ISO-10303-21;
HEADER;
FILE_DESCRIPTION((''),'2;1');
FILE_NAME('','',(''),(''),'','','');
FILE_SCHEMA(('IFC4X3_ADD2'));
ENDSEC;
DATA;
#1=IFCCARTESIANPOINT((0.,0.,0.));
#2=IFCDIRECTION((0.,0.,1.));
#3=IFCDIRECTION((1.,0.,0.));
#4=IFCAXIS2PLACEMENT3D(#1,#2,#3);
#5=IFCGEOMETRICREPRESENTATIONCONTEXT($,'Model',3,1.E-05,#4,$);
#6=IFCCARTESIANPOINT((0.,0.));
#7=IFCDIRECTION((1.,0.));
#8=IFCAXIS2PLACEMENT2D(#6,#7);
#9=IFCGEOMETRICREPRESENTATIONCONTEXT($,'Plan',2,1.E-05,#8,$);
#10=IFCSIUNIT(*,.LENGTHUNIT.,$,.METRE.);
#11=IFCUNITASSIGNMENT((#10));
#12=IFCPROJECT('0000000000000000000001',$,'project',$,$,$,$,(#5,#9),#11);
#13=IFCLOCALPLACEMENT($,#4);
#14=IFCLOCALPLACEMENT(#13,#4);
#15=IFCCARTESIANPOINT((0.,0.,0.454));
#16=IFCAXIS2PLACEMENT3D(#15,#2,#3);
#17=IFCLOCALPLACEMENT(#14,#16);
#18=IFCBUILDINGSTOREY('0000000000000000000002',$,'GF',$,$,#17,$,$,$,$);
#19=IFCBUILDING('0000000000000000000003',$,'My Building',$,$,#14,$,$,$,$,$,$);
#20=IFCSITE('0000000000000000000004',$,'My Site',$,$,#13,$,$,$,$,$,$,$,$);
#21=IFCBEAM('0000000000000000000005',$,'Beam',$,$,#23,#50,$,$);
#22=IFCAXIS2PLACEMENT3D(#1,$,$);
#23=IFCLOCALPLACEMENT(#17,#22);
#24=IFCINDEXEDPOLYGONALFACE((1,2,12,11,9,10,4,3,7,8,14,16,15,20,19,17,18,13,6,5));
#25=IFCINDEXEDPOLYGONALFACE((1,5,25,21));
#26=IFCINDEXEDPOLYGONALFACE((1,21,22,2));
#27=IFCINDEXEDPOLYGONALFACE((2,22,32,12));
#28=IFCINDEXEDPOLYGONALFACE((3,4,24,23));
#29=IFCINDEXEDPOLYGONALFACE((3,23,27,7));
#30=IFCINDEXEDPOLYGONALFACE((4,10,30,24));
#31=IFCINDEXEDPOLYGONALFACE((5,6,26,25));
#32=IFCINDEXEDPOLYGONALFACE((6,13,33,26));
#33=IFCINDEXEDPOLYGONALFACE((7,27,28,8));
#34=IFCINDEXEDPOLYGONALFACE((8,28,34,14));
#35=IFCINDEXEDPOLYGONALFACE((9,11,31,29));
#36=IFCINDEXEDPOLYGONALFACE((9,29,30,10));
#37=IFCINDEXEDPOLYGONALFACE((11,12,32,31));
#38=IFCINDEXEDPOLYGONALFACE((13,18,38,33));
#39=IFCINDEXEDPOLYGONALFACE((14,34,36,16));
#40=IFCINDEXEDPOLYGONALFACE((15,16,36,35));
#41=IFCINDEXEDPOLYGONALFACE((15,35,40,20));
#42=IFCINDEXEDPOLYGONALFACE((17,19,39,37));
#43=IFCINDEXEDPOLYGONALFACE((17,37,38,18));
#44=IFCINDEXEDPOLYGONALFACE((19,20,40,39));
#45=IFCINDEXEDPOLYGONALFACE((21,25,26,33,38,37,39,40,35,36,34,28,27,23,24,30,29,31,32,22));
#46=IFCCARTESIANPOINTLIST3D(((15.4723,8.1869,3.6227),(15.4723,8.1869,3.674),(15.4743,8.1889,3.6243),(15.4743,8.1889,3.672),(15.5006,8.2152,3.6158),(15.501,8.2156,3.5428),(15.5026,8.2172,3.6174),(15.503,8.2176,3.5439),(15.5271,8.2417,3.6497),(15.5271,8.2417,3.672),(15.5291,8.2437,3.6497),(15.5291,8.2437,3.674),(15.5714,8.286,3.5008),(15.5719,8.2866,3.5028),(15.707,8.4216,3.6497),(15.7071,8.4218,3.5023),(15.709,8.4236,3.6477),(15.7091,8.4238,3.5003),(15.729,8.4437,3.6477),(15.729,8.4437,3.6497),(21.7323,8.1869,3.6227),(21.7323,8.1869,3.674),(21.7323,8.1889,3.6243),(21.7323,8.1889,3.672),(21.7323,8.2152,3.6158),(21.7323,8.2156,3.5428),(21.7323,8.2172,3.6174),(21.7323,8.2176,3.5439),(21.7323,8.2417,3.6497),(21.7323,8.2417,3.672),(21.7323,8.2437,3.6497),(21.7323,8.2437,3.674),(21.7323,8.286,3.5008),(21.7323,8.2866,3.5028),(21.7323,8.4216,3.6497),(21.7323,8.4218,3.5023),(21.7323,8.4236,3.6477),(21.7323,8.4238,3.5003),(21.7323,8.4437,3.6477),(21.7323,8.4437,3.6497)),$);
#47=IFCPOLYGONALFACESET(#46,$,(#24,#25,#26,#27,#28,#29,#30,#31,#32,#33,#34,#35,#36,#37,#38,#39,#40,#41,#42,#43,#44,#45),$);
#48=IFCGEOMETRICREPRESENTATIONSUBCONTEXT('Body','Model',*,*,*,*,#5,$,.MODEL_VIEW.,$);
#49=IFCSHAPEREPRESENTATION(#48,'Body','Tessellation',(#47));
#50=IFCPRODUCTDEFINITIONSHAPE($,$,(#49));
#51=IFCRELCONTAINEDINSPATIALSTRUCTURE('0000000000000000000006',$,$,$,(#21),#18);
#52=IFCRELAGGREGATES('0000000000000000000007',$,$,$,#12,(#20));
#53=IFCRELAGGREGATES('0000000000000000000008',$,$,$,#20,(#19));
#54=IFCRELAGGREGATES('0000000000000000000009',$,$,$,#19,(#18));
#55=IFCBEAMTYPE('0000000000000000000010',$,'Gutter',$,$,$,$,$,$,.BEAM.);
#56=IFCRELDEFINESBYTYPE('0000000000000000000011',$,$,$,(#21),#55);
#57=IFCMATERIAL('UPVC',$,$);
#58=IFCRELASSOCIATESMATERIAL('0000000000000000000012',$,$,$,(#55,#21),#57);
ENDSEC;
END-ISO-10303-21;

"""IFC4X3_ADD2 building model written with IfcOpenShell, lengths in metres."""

from ifc_helpers import new_model, si_unit, frame, origin_with_axes, origin_2d_with_axis, place, context, subcontext, project, spatial, indexed_curve, outline, extrude, clip, halfspace, material, material_profile, profile_set, profile_usage, type_object, element, save


model = new_model("IFC4X3_ADD2")

# Units and contexts
model_context = context("Model", 3, precision=1e-05, world=origin_with_axes())
plan_context = context("Plan", 2, precision=1e-05, world=origin_2d_with_axis())
body_context = subcontext(model_context, "Body", "Model", "MODEL_VIEW")
ifc_project = project(units=[si_unit("LENGTHUNIT", "METRE")], contexts=[model_context, plan_context])

# Site, building, storey
site_placement = place(None, origin_with_axes())
site = spatial("IfcSite", under=ifc_project, at=site_placement, Name="My Site")
building_placement = place(site_placement, origin_with_axes())
building = spatial("IfcBuilding", under=site, at=building_placement, Name="My Building")
storey_placement = place(building_placement, frame((0.0, 0.0, 0.454), z_axis=(0.0, 0.0, 1.0), x_axis=(1.0, 0.0, 0.0)))
storey = spatial("IfcBuildingStorey", under=building, at=storey_placement, Name="GF")

# Shared definitions
ifc_material = material(Name="UPVC")

# Beam
ifc_material_profile_1 = material_profile(ifc_material, outline(indexed_curve([(0.0548, 0.1717), (0.002, 0.1717), (0.002, 0.124), (0.0303, 0.1171), (0.0307, 0.0436), (0.0996, 0.0025), (0.2349, 0.002), (0.2347, 0.1494), (0.2567, 0.1494), (0.2567, 0.1474), (0.2367, 0.1474), (0.2369, 0.0), (0.0991, 0.0005), (0.0287, 0.0425), (0.0283, 0.1155), (0.0, 0.1224), (0.0, 0.1737), (0.0568, 0.1737), (0.0568, 0.1494), (0.0548, 0.1494), (0.0548, 0.1717)])))
ifc_profile_set_1 = profile_set([ifc_material_profile_1])
ifc_profile_usage_1 = profile_usage(ifc_profile_set_1)
beam_type_1 = type_object("IfcBeamType", Name="Gutter", PredefinedType="BEAM", material=ifc_profile_set_1)
beam_1_placement = place(storey_placement, frame((15.4723, 8.1869, 3.5003), z_axis=(1.0, 0.0, 0.0), x_axis=(0.0, 1.0, 0.0)))
element("IfcBeam", 1, at=beam_1_placement, inside=storey, type_object=beam_type_1, material=ifc_profile_usage_1, Name="Beam", context=body_context, shape_type="Clipping", body=[
    clip(extrude(outline(indexed_curve([(0.0548, 0.1717), (0.002, 0.1717), (0.002, 0.124), (0.0303, 0.1171), (0.0307, 0.0436), (0.0996, 0.0025), (0.2349, 0.002), (0.2347, 0.1494), (0.2567, 0.1494), (0.2567, 0.1474), (0.2367, 0.1474), (0.2369, 0.0), (0.0991, 0.0005), (0.0287, 0.0425), (0.0283, 0.1155), (0.0, 0.1224), (0.0, 0.1737), (0.0568, 0.1737), (0.0568, 0.1494), (0.0548, 0.1494), (0.0548, 0.1717)])), origin_with_axes(), (0.0, 0.0, 1.0), 6.26), halfspace(frame((0.0, -3.9543, 0.0), z_axis=(0.707107, 0.0, -0.707107), x_axis=(0.0, -1.0, 0.0)), False)),
])

save(model, "model.ifc")
